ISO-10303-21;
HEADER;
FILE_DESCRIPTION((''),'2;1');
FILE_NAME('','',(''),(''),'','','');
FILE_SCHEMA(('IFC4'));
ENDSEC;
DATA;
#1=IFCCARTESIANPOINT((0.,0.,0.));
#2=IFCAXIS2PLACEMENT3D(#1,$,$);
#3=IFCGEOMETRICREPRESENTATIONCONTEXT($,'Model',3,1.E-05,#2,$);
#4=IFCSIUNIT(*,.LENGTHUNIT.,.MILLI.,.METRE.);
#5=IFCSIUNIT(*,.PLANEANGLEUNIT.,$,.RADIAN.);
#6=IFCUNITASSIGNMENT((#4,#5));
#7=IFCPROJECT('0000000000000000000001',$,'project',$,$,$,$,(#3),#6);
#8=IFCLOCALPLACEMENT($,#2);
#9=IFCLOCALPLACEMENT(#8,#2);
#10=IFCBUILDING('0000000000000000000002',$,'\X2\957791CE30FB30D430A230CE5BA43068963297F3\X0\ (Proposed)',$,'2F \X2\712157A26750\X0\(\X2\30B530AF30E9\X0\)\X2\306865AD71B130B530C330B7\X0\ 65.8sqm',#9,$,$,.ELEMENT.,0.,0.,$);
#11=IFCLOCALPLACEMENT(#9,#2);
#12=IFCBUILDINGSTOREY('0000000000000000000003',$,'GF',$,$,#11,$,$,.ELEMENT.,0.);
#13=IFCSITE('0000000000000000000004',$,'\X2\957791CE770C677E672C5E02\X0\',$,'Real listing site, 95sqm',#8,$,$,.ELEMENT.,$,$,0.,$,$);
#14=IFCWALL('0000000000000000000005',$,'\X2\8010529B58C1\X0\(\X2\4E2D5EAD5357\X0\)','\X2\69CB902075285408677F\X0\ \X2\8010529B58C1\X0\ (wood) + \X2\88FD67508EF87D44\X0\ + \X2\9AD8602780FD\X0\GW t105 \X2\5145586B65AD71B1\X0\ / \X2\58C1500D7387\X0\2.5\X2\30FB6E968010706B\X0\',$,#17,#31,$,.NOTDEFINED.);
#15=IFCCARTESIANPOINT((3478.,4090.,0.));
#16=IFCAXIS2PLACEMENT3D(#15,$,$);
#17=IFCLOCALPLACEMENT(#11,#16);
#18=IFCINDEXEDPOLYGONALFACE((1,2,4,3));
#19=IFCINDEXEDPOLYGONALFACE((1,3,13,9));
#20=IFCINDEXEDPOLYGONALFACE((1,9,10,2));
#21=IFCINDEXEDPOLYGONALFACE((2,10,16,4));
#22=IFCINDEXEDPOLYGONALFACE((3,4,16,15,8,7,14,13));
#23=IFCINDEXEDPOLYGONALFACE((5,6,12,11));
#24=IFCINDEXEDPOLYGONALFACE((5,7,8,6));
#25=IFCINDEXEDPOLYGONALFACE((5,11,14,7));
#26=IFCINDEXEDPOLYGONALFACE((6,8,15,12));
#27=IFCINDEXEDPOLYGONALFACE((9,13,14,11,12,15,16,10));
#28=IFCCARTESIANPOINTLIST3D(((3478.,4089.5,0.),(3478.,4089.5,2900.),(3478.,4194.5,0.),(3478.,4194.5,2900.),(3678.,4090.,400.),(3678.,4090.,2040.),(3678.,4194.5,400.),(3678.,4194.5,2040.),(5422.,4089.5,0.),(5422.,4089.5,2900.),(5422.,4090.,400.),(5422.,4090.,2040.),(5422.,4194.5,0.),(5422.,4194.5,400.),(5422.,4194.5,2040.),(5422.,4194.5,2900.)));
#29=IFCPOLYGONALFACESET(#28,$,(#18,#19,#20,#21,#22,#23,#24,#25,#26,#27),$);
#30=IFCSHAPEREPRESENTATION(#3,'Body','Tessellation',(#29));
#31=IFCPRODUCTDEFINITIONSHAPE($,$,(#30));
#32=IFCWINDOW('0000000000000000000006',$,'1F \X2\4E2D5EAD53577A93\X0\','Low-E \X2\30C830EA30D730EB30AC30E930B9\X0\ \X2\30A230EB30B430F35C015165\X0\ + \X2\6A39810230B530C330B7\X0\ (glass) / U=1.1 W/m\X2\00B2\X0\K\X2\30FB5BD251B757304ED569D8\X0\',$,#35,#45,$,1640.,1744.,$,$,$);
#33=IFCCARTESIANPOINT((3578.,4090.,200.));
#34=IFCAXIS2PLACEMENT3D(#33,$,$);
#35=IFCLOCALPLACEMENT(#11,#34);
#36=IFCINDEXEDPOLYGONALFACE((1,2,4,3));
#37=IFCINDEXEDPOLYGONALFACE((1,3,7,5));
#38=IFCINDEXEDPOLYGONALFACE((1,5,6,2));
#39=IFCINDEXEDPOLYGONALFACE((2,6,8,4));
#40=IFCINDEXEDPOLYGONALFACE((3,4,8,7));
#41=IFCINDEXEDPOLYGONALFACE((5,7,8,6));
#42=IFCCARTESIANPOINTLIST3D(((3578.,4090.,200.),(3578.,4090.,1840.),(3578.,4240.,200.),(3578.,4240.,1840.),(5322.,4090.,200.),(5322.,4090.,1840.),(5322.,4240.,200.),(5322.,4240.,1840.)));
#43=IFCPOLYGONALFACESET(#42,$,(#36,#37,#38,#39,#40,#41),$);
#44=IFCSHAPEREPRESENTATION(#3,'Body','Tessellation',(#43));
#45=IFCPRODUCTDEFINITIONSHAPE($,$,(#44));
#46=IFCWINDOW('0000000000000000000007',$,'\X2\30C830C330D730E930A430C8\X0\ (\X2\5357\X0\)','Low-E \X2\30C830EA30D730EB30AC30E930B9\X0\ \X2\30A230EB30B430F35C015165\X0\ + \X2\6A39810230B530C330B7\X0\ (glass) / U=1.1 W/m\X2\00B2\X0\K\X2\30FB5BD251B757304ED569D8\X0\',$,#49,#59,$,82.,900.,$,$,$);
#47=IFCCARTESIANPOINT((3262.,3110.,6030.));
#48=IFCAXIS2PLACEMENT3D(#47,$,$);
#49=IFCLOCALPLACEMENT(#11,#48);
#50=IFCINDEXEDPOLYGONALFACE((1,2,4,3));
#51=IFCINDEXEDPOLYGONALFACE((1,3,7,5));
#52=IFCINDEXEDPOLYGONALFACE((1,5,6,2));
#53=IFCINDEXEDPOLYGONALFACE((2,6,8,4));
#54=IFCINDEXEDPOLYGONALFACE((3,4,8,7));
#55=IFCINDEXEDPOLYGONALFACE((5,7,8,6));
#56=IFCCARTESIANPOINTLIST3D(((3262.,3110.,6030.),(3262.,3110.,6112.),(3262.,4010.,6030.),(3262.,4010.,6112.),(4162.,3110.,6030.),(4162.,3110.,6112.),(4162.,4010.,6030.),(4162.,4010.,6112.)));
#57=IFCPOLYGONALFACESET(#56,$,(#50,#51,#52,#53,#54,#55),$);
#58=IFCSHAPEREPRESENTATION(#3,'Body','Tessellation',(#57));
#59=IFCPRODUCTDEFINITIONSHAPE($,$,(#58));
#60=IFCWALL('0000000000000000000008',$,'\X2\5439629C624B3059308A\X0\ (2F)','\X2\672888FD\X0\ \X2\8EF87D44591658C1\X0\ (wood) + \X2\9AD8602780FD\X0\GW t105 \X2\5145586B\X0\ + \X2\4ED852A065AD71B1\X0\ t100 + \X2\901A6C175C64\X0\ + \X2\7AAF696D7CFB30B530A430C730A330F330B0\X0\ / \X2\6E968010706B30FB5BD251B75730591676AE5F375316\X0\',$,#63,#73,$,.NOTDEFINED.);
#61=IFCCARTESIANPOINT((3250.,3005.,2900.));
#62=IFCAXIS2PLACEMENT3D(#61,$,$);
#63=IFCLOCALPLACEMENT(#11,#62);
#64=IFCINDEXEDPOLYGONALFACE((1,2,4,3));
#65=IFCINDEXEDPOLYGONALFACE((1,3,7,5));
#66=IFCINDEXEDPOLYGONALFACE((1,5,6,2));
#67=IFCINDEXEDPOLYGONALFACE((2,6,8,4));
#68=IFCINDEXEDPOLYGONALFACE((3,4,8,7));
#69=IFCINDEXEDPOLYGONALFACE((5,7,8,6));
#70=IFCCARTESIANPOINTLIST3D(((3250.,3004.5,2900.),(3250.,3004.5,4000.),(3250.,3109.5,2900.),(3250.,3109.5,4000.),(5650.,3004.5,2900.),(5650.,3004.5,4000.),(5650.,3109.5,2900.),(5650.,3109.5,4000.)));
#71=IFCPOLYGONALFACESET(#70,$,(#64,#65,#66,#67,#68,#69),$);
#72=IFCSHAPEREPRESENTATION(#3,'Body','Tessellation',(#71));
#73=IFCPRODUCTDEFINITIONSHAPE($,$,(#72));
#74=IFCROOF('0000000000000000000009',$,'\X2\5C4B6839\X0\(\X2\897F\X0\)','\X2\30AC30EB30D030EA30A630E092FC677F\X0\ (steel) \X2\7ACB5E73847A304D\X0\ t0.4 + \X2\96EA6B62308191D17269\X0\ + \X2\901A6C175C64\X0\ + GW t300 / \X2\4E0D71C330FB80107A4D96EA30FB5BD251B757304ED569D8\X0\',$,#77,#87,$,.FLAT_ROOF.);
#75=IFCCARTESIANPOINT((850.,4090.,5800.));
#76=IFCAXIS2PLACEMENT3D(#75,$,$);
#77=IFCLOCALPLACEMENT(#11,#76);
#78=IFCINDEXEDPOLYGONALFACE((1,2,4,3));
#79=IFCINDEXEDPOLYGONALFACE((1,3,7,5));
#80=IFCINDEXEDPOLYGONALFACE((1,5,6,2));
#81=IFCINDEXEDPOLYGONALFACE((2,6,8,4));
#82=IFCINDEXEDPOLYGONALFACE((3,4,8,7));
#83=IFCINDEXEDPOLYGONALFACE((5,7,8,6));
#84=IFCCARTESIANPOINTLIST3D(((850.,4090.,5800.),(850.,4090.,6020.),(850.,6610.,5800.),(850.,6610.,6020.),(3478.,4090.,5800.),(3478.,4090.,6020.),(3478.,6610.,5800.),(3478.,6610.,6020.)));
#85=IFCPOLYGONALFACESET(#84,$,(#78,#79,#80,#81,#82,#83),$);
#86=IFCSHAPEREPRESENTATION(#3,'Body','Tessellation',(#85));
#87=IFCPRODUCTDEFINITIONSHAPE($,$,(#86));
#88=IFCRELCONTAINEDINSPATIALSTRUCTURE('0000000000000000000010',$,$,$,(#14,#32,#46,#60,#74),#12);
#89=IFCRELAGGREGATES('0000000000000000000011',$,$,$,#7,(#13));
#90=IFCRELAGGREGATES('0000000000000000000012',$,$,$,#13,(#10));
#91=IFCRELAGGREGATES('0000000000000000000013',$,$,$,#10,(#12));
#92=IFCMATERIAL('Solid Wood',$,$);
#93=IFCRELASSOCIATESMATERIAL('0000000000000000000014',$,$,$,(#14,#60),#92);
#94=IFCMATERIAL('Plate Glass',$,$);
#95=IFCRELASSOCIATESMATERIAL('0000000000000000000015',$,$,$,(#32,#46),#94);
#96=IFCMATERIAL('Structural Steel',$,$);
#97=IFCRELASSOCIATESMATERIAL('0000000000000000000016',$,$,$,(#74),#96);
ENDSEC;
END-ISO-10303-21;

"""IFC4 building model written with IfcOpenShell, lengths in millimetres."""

from ifc_helpers import new_model, si_unit, frame, frame_2d, origin, place, context, project, spatial, rectangle, extrude, material, element, fill, save


model = new_model("IFC4")

# Units and contexts
model_context = context("Model", 3, precision=1e-05, world=origin())
ifc_project = project(units=[si_unit("LENGTHUNIT", "METRE", prefix="MILLI"), si_unit("PLANEANGLEUNIT", "RADIAN")], contexts=[model_context])

# Site, building, storey
site_placement = place(None, origin())
site = spatial("IfcSite", under=ifc_project, at=site_placement, Name="長野県松本市", ObjectType="Real listing site, 95sqm", CompositionType="ELEMENT", RefElevation=0.0)
building_placement = place(site_placement, origin())
building = spatial("IfcBuilding", under=site, at=building_placement, Name="長野・ピアノ室と防音 (Proposed)", ObjectType="2F 無垢材(サクラ)と断熱サッシ 65.8sqm", CompositionType="ELEMENT", ElevationOfRefHeight=0.0, ElevationOfTerrain=0.0)
storey_placement = place(building_placement, origin())
storey = spatial("IfcBuildingStorey", under=building, at=storey_placement, Name="GF", CompositionType="ELEMENT", Elevation=0.0)

# Shared definitions
ifc_material_1 = material(Name="Solid Wood")

# Wall, opening, window
wall_1_placement = place(storey_placement, frame((3478.0, 4090.0, 0.0)))
wall_1 = element("IfcWall", 1, at=wall_1_placement, inside=storey, material=ifc_material_1, Name="耐力壁(中庭南)", Description="構造用合板 耐力壁 (wood) + 製材軸組 + 高性能GW t105 充填断熱 / 壁倍率2.5・準耐火", PredefinedType="NOTDEFINED", context=model_context, shape_type="SweptSolid", body=[
    extrude(rectangle(XDim=1944.0, YDim=105.0, at=frame_2d((972.0, 52.0))), frame((3478.0, 4090.0, 0.0)), (0.0, 0.0, 1.0), 2900.0),
])
opening_placement = place(storey_placement, frame((3578.0, 4090.0, 200.0)))
opening = element("IfcOpeningElement", 2, at=opening_placement, cuts=wall_1, PredefinedType="NOTDEFINED", context=model_context, shape_type="SweptSolid", body=[
    extrude(rectangle(XDim=1744.0, YDim=150.0, at=frame_2d((872.0, 75.0))), frame((3578.0, 4090.0, 200.0)), (0.0, 0.0, 1.0), 1640.0),
])
ifc_material_2 = material(Name="Plate Glass")
window_1_placement = place(storey_placement, frame((3578.0, 4090.0, 200.0)))
window_1 = element("IfcWindow", 3, at=window_1_placement, inside=storey, material=ifc_material_2, Name="1F 中庭南窓", Description="Low-E トリプルガラス アルゴン封入 + 樹脂サッシ (glass) / U=1.1 W/m²K・寒冷地仕様", OverallHeight=1640.0, OverallWidth=1744.0, context=model_context, shape_type="SweptSolid", body=[
    extrude(rectangle(XDim=1744.0, YDim=150.0, at=frame_2d((872.0, 75.0))), frame((3578.0, 4090.0, 200.0)), (0.0, 0.0, 1.0), 1640.0),
])
fill(opening, window_1)

# Window
window_2_placement = place(storey_placement, frame((3262.0, 3110.0, 6030.0)))
element("IfcWindow", 4, at=window_2_placement, inside=storey, material=ifc_material_2, Name="トップライト (南)", Description="Low-E トリプルガラス アルゴン封入 + 樹脂サッシ (glass) / U=1.1 W/m²K・寒冷地仕様", OverallHeight=82.0, OverallWidth=900.0, context=model_context, shape_type="SweptSolid", body=[
    extrude(rectangle(XDim=900.0, YDim=900.0, at=frame_2d((450.0, 450.0))), frame((3262.0, 3110.0, 6030.0)), (0.0, 0.0, 1.0), 82.0),
])

# Wall
wall_2_placement = place(storey_placement, frame((3250.0, 3005.0, 2900.0)))
element("IfcWall", 5, at=wall_2_placement, inside=storey, material=ifc_material_1, Name="吹抜手すり (2F)", Description="木製 軸組外壁 (wood) + 高性能GW t105 充填 + 付加断熱 t100 + 通気層 + 窯業系サイディング / 準耐火・寒冷地外皮強化", PredefinedType="NOTDEFINED", context=model_context, shape_type="SweptSolid", body=[
    extrude(rectangle(XDim=2400.0, YDim=105.0, at=frame_2d((1200.0, 52.0))), frame((3250.0, 3005.0, 2900.0)), (0.0, 0.0, 1.0), 1100.0),
])

# Roof
ifc_material_3 = material(Name="Structural Steel")
for number, where, name in (
    (6, (850.0, 4090.0, 5800.0), "屋根(西)"),
):
    element("IfcRoof", number, at=place(storey_placement, frame(where)), inside=storey, material=ifc_material_3, Name=name, Description="ガルバリウム鋼板 (steel) 立平葺き t0.4 + 雪止め金物 + 通気層 + GW t300 / 不燃・耐積雪・寒冷地仕様", PredefinedType="FLAT_ROOF", context=model_context, shape_type="SweptSolid", body=[
        extrude(rectangle(XDim=2628.0, YDim=2520.0, at=frame_2d((1314.0, 1260.0))), frame((850.0, 4090.0, 5800.0)), (0.0, 0.0, 1.0), 220.0),
    ])

save(model, "model.ifc")
